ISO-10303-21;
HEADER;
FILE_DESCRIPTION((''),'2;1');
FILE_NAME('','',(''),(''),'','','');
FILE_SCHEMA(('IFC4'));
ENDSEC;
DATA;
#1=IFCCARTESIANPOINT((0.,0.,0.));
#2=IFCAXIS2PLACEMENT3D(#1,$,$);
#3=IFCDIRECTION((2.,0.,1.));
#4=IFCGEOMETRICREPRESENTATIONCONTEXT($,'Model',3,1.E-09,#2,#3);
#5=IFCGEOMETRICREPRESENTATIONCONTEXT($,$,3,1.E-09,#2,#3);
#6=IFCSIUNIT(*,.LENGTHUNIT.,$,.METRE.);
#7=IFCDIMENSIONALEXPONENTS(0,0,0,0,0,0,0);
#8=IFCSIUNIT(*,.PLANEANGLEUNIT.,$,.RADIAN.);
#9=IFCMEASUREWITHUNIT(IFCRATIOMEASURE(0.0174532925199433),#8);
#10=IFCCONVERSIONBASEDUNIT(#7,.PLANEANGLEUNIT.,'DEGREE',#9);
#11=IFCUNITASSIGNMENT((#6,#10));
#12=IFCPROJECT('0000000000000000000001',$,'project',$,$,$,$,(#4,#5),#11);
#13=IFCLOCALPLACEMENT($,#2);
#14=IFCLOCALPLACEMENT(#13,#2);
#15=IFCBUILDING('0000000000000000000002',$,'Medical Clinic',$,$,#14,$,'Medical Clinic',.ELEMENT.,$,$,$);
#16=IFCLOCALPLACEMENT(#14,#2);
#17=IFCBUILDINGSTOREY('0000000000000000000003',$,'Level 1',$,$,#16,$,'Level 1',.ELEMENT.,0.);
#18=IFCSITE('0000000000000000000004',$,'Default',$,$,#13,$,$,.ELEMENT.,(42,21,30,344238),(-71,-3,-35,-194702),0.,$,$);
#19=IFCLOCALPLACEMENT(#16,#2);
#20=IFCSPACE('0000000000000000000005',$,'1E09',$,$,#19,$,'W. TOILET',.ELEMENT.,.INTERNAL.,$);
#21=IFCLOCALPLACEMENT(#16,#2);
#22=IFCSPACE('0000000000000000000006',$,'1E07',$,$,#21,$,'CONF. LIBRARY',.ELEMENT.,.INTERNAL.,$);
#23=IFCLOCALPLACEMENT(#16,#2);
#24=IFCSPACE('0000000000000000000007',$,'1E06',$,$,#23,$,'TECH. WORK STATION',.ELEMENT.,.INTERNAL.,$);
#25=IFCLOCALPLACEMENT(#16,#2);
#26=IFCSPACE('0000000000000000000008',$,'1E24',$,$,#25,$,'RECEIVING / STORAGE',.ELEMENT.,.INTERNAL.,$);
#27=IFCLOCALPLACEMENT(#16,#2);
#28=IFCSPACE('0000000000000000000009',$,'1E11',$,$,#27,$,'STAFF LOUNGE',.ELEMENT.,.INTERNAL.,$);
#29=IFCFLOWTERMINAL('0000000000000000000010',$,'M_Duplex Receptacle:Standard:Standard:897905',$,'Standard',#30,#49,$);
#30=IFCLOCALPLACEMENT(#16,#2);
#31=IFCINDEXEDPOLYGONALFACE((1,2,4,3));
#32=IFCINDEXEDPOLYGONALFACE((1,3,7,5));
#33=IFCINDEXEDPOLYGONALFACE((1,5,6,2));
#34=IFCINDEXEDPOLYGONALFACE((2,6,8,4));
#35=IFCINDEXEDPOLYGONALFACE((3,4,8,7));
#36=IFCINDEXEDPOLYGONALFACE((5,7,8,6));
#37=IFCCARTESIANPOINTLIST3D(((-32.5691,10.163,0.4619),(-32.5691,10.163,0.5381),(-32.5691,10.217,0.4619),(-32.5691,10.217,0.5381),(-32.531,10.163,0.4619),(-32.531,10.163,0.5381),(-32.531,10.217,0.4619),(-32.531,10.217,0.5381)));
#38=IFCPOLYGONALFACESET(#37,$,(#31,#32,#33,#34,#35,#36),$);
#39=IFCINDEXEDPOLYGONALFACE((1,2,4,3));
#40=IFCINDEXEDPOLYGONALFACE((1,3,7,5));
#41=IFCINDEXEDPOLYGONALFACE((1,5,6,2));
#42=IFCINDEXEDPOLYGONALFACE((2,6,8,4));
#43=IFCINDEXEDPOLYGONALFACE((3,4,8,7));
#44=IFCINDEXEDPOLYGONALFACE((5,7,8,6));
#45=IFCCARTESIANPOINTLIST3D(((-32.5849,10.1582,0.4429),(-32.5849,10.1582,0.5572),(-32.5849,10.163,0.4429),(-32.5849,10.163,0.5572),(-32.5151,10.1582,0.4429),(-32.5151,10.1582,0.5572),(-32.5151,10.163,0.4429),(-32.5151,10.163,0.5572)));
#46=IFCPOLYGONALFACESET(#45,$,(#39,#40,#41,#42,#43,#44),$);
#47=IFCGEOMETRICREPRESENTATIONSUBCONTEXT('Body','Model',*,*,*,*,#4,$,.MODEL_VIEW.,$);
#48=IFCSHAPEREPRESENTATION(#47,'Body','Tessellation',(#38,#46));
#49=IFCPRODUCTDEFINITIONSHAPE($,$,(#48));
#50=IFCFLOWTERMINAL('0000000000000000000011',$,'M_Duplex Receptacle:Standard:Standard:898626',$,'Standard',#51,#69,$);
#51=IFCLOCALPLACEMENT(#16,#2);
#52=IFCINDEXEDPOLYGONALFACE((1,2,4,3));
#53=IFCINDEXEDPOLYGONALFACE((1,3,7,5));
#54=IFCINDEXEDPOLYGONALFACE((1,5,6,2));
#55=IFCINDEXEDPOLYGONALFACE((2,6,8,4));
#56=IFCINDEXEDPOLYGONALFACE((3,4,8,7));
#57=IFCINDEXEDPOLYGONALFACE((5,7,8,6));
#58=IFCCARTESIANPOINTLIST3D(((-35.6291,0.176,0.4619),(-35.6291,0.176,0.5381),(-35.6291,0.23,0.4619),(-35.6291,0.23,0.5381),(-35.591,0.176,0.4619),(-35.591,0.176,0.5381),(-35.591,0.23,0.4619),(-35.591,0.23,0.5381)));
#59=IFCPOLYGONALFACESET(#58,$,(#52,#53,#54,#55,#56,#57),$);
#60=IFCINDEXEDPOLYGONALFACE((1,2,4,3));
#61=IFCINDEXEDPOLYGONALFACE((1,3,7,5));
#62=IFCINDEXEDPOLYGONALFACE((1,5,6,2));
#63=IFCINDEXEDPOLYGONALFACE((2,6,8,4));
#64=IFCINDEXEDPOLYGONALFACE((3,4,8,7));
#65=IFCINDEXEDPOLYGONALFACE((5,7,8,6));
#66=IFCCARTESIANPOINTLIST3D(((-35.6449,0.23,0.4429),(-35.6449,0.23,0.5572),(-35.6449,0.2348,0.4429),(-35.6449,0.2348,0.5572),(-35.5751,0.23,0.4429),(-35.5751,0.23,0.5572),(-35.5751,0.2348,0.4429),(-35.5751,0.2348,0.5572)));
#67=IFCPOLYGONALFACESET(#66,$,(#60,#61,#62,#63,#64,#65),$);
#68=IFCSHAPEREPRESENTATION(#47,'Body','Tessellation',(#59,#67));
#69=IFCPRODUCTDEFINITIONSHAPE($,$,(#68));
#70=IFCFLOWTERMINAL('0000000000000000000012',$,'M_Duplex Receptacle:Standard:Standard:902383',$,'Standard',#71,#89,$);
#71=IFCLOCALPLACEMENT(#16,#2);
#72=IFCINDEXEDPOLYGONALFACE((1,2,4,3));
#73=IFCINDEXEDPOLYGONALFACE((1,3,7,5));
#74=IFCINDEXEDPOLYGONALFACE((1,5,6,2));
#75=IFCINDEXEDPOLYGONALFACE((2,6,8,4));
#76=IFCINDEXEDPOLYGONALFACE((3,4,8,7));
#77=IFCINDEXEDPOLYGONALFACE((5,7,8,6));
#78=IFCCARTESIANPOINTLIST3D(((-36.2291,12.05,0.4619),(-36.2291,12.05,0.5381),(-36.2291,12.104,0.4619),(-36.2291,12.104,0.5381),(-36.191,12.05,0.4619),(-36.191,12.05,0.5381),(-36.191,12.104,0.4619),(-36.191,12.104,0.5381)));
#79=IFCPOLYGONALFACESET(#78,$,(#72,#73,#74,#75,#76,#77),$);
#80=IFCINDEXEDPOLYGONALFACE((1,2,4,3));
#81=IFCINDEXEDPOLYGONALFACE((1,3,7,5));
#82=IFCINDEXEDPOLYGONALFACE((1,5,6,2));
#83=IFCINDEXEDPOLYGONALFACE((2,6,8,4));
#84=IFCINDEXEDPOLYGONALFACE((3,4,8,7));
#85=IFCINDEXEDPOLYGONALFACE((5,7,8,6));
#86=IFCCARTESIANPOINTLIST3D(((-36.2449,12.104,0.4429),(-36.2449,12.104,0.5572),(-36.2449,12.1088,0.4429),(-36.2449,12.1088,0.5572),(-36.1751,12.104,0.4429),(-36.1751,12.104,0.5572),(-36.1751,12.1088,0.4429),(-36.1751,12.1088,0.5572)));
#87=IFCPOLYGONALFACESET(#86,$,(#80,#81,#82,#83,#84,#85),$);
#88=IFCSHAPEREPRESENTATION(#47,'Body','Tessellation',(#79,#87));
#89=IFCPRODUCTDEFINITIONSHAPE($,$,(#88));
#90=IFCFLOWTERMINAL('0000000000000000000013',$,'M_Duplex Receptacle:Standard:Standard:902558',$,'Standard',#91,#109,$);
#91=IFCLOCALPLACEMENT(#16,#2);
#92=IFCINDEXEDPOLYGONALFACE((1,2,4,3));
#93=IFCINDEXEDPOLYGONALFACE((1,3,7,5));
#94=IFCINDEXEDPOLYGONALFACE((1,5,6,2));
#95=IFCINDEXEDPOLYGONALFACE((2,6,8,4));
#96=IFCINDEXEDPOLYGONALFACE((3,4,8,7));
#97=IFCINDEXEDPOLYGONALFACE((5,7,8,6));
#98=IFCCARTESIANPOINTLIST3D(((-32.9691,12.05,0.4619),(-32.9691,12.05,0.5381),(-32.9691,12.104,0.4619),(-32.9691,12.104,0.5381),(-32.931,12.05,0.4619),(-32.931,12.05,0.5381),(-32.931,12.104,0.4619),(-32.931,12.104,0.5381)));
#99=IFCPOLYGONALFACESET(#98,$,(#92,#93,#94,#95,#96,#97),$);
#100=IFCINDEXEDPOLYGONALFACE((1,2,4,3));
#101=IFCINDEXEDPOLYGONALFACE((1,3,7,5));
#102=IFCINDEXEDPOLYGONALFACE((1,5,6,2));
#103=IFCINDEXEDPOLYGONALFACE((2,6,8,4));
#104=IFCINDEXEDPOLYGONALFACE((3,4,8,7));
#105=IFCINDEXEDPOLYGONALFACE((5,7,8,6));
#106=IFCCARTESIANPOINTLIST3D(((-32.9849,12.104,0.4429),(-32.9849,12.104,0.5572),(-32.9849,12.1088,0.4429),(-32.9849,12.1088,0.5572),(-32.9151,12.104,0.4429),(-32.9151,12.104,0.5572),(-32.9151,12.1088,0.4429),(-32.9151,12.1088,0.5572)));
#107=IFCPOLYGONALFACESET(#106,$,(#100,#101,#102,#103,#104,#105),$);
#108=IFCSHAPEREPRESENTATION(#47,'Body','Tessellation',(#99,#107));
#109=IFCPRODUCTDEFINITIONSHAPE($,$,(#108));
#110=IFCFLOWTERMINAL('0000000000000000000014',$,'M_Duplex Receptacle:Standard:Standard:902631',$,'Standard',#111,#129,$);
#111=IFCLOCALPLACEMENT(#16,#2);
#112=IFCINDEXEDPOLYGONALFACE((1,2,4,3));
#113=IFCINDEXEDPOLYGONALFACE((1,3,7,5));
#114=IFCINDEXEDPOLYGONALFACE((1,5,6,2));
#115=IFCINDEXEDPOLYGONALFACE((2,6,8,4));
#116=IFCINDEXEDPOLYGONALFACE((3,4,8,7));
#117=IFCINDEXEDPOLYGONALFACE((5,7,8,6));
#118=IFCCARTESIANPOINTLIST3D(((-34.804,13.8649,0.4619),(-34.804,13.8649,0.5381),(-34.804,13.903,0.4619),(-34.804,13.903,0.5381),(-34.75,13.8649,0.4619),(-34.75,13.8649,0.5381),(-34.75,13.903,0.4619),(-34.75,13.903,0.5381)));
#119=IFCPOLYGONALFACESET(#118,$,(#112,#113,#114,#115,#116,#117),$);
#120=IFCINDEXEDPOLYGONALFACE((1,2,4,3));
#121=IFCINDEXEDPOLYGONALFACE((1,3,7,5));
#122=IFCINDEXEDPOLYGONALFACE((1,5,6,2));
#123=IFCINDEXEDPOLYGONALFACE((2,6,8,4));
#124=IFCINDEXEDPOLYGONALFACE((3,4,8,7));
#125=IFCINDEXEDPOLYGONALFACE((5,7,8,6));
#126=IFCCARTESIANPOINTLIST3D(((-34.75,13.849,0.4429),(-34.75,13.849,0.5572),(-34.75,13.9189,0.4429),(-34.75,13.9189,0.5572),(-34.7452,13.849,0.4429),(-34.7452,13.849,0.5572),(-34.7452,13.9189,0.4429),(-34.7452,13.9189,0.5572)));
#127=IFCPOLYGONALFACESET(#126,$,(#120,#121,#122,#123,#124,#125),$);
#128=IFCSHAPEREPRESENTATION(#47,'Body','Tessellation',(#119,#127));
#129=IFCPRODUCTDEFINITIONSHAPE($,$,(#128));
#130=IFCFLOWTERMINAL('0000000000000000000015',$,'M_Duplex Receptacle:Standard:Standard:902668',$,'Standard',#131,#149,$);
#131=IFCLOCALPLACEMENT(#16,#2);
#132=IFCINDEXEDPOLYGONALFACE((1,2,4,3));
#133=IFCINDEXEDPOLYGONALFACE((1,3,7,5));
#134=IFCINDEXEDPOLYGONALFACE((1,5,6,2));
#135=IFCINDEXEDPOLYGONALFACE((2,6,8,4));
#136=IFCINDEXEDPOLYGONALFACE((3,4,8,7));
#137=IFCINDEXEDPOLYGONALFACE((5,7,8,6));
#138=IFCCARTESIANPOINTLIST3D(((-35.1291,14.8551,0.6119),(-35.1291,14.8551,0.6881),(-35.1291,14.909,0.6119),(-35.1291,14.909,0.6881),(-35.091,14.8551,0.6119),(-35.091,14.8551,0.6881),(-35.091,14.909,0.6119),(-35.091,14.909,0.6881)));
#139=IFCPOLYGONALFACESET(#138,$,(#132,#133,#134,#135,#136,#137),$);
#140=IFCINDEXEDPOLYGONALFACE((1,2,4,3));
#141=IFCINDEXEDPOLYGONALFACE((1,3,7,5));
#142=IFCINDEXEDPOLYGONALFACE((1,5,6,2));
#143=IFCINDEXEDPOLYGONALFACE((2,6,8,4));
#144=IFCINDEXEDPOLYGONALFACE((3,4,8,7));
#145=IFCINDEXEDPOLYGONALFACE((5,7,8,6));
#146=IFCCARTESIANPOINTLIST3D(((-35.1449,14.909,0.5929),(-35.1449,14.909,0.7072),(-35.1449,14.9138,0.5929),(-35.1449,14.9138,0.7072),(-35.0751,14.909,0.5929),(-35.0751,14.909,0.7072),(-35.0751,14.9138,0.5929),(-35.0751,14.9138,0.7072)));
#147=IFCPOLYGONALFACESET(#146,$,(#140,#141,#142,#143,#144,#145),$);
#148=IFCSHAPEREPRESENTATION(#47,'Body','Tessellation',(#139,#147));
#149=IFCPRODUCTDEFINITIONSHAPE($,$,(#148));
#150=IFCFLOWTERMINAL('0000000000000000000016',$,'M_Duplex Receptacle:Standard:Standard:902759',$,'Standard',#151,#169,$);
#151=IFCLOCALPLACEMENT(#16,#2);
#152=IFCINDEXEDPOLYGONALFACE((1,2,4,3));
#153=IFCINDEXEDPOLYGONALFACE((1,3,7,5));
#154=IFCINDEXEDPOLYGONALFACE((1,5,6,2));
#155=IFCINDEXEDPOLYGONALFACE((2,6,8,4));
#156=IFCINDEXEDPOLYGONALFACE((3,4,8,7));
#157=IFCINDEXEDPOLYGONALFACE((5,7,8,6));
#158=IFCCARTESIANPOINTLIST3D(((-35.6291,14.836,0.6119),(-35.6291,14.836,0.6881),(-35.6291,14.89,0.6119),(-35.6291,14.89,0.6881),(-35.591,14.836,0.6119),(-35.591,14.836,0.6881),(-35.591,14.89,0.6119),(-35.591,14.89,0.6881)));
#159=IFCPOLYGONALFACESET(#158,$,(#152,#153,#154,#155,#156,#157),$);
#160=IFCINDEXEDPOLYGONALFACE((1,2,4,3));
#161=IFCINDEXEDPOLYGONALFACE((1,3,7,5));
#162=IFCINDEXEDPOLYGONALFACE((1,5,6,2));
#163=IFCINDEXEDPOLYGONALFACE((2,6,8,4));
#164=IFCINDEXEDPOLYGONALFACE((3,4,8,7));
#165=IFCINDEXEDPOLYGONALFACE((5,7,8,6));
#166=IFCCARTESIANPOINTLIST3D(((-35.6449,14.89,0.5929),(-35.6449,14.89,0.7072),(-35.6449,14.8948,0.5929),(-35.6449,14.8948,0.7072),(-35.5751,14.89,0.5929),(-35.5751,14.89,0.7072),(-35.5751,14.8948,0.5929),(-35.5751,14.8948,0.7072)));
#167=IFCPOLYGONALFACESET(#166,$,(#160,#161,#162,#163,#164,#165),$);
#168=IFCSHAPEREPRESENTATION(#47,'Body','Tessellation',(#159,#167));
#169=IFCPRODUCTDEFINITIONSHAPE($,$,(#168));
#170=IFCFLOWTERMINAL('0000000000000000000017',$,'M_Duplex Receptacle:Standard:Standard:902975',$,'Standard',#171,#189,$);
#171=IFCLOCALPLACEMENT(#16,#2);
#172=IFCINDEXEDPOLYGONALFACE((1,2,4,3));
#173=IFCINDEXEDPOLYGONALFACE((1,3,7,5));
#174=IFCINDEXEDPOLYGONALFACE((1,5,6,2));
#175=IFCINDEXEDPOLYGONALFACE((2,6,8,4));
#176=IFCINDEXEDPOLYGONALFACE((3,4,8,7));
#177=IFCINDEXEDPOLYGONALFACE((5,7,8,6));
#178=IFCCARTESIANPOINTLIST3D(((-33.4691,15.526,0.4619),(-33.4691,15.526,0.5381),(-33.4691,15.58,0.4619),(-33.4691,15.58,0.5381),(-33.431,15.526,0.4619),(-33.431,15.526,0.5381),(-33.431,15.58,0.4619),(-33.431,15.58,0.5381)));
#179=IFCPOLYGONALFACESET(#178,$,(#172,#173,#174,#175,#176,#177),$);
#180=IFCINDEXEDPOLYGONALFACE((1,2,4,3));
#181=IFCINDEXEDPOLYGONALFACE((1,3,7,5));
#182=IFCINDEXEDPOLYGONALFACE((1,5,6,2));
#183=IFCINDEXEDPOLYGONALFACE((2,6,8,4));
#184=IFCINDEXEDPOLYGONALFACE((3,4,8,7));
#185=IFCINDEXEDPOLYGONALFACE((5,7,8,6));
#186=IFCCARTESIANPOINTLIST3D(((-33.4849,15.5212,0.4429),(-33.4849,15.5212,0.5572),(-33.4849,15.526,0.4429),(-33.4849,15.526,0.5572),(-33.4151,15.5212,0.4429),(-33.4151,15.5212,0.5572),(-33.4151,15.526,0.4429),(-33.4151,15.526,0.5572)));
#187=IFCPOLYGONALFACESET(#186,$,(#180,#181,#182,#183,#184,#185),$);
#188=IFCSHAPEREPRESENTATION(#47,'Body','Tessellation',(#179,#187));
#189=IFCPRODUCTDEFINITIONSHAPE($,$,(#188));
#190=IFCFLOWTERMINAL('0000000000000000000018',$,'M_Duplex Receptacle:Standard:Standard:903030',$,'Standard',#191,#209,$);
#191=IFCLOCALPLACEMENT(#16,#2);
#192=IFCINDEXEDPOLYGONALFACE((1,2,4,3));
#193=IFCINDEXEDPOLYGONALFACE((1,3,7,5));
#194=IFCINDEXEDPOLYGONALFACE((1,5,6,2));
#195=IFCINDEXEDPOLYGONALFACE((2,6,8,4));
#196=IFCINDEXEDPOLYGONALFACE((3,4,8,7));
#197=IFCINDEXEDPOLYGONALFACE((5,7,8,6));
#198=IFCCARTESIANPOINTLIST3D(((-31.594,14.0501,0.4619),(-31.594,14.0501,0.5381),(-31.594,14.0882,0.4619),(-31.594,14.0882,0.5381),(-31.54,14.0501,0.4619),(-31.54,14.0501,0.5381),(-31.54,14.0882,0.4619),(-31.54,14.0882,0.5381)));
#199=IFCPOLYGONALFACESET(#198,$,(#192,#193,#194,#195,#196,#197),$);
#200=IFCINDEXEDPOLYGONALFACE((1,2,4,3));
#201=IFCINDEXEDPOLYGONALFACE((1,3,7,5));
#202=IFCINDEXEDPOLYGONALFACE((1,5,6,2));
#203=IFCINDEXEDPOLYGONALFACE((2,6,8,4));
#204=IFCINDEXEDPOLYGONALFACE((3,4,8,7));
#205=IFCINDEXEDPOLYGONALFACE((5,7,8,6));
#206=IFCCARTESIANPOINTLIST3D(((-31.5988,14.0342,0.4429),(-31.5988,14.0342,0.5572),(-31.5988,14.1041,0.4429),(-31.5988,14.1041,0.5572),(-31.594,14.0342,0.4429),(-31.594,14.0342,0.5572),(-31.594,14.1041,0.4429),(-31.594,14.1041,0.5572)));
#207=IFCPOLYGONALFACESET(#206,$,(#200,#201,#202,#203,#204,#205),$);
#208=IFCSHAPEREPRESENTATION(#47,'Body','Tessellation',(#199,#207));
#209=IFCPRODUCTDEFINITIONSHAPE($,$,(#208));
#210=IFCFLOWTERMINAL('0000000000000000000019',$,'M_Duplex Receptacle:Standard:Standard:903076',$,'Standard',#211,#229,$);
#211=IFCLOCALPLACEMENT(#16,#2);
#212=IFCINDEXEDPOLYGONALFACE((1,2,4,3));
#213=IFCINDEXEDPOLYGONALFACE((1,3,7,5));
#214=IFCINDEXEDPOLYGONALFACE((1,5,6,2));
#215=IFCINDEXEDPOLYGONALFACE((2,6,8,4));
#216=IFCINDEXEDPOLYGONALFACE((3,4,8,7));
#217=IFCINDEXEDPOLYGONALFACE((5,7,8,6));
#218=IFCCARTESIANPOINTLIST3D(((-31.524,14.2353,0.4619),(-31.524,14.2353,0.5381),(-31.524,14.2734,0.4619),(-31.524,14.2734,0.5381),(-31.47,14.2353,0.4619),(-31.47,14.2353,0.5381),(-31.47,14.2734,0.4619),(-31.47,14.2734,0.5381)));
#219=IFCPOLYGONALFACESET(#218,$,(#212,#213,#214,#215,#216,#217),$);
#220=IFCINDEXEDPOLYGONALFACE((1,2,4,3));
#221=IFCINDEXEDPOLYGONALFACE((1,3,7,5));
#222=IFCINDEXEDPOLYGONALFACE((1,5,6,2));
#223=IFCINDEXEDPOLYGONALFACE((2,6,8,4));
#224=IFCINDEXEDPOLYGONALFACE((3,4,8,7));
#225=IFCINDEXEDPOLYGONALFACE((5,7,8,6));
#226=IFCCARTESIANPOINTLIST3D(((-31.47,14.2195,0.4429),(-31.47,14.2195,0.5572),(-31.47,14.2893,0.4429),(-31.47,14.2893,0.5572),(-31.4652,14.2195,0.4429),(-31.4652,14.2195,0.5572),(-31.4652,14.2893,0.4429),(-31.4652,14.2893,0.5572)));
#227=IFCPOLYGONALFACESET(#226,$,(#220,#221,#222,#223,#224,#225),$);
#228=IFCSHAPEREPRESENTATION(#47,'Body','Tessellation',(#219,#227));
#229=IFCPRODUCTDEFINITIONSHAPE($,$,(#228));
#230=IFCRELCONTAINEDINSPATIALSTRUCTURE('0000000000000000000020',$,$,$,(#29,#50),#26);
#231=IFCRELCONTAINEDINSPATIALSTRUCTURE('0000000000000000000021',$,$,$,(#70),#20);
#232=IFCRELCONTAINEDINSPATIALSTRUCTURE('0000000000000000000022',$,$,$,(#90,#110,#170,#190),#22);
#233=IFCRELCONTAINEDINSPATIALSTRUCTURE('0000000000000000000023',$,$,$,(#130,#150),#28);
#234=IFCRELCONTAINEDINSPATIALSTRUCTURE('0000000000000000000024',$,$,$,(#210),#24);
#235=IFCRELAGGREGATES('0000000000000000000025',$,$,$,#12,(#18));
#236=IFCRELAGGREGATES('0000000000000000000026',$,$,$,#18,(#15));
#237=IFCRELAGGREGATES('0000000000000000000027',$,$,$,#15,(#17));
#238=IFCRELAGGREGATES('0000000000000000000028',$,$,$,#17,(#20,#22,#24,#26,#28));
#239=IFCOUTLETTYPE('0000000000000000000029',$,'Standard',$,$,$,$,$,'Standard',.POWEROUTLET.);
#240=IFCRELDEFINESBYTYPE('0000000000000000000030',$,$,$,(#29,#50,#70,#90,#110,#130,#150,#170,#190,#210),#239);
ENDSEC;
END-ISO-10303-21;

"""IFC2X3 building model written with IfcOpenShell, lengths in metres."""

from ifc_helpers import new_model, entity, si_unit, converted_unit, direction, frame, frame_2d, origin, origin_2d_with_axis, place, context, subcontext, project, spatial, rectangle, extrude, source, transform, mapped, type_object, type_shapes, element, save


model = new_model("IFC2X3")

# Units and contexts
model_context = context("Model", 3, precision=1e-09, world=origin(), true_north=direction((2.0, 0.0, 1.0)))
context_of_model = context(None, 3, precision=1e-09, world=origin(), true_north=direction((2.0, 0.0, 1.0)))
body_context = subcontext(model_context, "Body", "Model", "MODEL_VIEW")
ifc_project = project(units=[si_unit("LENGTHUNIT", "METRE"), converted_unit("PLANEANGLEUNIT", "DEGREE", entity("IfcRatioMeasure", 0.0174532925199433), si_unit("PLANEANGLEUNIT", "RADIAN"), dimensions=[0, 0, 0, 0, 0, 0, 0])], contexts=[model_context, context_of_model])

# Site, building, storey, space
site_placement = place(None, origin())
site = spatial("IfcSite", under=ifc_project, at=site_placement, Name="Default", CompositionType="ELEMENT", RefLatitude=(42, 21, 30, 344238), RefLongitude=(-71, -3, -35, -194702), RefElevation=0.0)
building_placement = place(site_placement, origin())
building = spatial("IfcBuilding", under=site, at=building_placement, Name="Medical Clinic", LongName="Medical Clinic", CompositionType="ELEMENT")
storey_placement = place(building_placement, origin())
storey = spatial("IfcBuildingStorey", under=building, at=storey_placement, Name="Level 1", LongName="Level 1", CompositionType="ELEMENT", Elevation=0.0)
space_1_placement = place(storey_placement, origin())
space_1 = spatial("IfcSpace", under=storey, at=space_1_placement, Name="1E09", LongName="W. TOILET", CompositionType="ELEMENT", InteriorOrExteriorSpace="INTERNAL")

# Shared definitions
space_2_placement = place(storey_placement, origin())
space_2 = spatial("IfcSpace", under=storey, at=space_2_placement, Name="1E07", LongName="CONF. LIBRARY", CompositionType="ELEMENT", InteriorOrExteriorSpace="INTERNAL")

# Shared definitions
space_3_placement = place(storey_placement, origin())
space_3 = spatial("IfcSpace", under=storey, at=space_3_placement, Name="1E06", LongName="TECH. WORK STATION", CompositionType="ELEMENT", InteriorOrExteriorSpace="INTERNAL")

# Shared definitions
space_4_placement = place(storey_placement, origin())
space_4 = spatial("IfcSpace", under=storey, at=space_4_placement, Name="1E24", LongName="RECEIVING / STORAGE", CompositionType="ELEMENT", InteriorOrExteriorSpace="INTERNAL")

# Flow terminals
outlet_type = type_object("IfcOutletType", Name="Standard", ElementType="Standard", PredefinedType="POWEROUTLET")
shared_shape_1 = source(origin(), body_context, "Body", "SweptSolid", [
    extrude(rectangle(XDim=0.0381, YDim=0.0762, at=origin_2d_with_axis()), frame((0.0, 0.0, -0.054), z_axis=(0.0, 0.0, 1.0), x_axis=(-1.0, 0.0, 0.0)), (0.0, 0.0, 1.0), 0.054),
    extrude(rectangle(XDim=0.0698, YDim=0.1143, at=frame_2d((0.0, 0.0), x_axis=(1.0, 0.0))), frame((0.0, 0.0, 0.0), z_axis=(0.0, 0.0, 1.0), x_axis=(-1.0, 0.0, 0.0)), (0.0, 0.0, 1.0), 0.0048),
])
type_shapes(outlet_type, [shared_shape_1])
for number, where, z_axis, x_axis, name in (
    (1, (-32.55, 10.163, 0.5), (0.0, -1.0, 0.0), (1.0, 0.0, 0.0), "M_Duplex Receptacle:Standard:Standard:897905"),
    (2, (-35.61, 0.23, 0.5), (0.0, 1.0, 0.0), (-1.0, 0.0, 0.0), "M_Duplex Receptacle:Standard:Standard:898626"),
):
    element("IfcFlowTerminal", number, at=place(space_4_placement, frame(where, z_axis=z_axis, x_axis=x_axis)), inside=space_4, type_object=outlet_type, Name=name, ObjectType="Standard", context=body_context, shape_type="MappedRepresentation", body=[
        mapped(shared_shape_1, transform((0.0, 0.0, 0.0), scale=1.0)),
    ])
flow_terminal_1_placement = place(space_1_placement, frame((-36.21, 12.104, 0.5), z_axis=(0.0, 1.0, 0.0), x_axis=(-1.0, 0.0, 0.0)))
element("IfcFlowTerminal", 3, at=flow_terminal_1_placement, inside=space_1, type_object=outlet_type, Name="M_Duplex Receptacle:Standard:Standard:902383", ObjectType="Standard", context=body_context, shape_type="MappedRepresentation", body=[
    mapped(shared_shape_1, transform((0.0, 0.0, 0.0), scale=1.0)),
])
for number, where, z_axis, x_axis, name in (
    (4, (-32.95, 12.104, 0.5), (0.0, 1.0, 0.0), (-1.0, 0.0, 0.0), "M_Duplex Receptacle:Standard:Standard:902558"),
    (5, (-34.75, 13.884, 0.5), (1.0, 0.0, 0.0), (0.0, 1.0, 0.0), "M_Duplex Receptacle:Standard:Standard:902631"),
):
    element("IfcFlowTerminal", number, at=place(space_2_placement, frame(where, z_axis=z_axis, x_axis=x_axis)), inside=space_2, type_object=outlet_type, Name=name, ObjectType="Standard", context=body_context, shape_type="MappedRepresentation", body=[
        mapped(shared_shape_1, transform((0.0, 0.0, 0.0), scale=1.0)),
    ])

# Shared definitions
space_5_placement = place(storey_placement, origin())
space_5 = spatial("IfcSpace", under=storey, at=space_5_placement, Name="1E11", LongName="STAFF LOUNGE", CompositionType="ELEMENT", InteriorOrExteriorSpace="INTERNAL")

# Flow terminals
for number, where, z_axis, x_axis, name in (
    (6, (-35.11, 14.909, 0.65), (0.0, 1.0, 0.0), (-1.0, 0.0, 0.0), "M_Duplex Receptacle:Standard:Standard:902668"),
    (7, (-35.61, 14.89, 0.65), (0.0, 1.0, 0.0), (-1.0, 0.0, 0.0), "M_Duplex Receptacle:Standard:Standard:902759"),
):
    element("IfcFlowTerminal", number, at=place(space_5_placement, frame(where, z_axis=z_axis, x_axis=x_axis)), inside=space_5, type_object=outlet_type, Name=name, ObjectType="Standard", context=body_context, shape_type="MappedRepresentation", body=[
        mapped(shared_shape_1, transform((0.0, 0.0, 0.0), scale=1.0)),
    ])
for number, where, z_axis, x_axis, name in (
    (8, (-33.45, 15.526, 0.5), (0.0, -1.0, 0.0), (1.0, 0.0, 0.0), "M_Duplex Receptacle:Standard:Standard:902975"),
    (9, (-31.594, 14.0692, 0.5), (-1.0, 0.0, 0.0), (0.0, -1.0, 0.0), "M_Duplex Receptacle:Standard:Standard:903030"),
):
    element("IfcFlowTerminal", number, at=place(space_2_placement, frame(where, z_axis=z_axis, x_axis=x_axis)), inside=space_2, type_object=outlet_type, Name=name, ObjectType="Standard", context=body_context, shape_type="MappedRepresentation", body=[
        mapped(shared_shape_1, transform((0.0, 0.0, 0.0), scale=1.0)),
    ])
for number, where, z_axis, x_axis, name in (
    (10, (-31.47, 14.2544, 0.5), (1.0, 0.0, 0.0), (0.0, 1.0, 0.0), "M_Duplex Receptacle:Standard:Standard:903076"),
):
    element("IfcFlowTerminal", number, at=place(space_3_placement, frame(where, z_axis=z_axis, x_axis=x_axis)), inside=space_3, type_object=outlet_type, Name=name, ObjectType="Standard", context=body_context, shape_type="MappedRepresentation", body=[
        mapped(shared_shape_1, transform((0.0, 0.0, 0.0), scale=1.0)),
    ])

save(model, "model.ifc")
